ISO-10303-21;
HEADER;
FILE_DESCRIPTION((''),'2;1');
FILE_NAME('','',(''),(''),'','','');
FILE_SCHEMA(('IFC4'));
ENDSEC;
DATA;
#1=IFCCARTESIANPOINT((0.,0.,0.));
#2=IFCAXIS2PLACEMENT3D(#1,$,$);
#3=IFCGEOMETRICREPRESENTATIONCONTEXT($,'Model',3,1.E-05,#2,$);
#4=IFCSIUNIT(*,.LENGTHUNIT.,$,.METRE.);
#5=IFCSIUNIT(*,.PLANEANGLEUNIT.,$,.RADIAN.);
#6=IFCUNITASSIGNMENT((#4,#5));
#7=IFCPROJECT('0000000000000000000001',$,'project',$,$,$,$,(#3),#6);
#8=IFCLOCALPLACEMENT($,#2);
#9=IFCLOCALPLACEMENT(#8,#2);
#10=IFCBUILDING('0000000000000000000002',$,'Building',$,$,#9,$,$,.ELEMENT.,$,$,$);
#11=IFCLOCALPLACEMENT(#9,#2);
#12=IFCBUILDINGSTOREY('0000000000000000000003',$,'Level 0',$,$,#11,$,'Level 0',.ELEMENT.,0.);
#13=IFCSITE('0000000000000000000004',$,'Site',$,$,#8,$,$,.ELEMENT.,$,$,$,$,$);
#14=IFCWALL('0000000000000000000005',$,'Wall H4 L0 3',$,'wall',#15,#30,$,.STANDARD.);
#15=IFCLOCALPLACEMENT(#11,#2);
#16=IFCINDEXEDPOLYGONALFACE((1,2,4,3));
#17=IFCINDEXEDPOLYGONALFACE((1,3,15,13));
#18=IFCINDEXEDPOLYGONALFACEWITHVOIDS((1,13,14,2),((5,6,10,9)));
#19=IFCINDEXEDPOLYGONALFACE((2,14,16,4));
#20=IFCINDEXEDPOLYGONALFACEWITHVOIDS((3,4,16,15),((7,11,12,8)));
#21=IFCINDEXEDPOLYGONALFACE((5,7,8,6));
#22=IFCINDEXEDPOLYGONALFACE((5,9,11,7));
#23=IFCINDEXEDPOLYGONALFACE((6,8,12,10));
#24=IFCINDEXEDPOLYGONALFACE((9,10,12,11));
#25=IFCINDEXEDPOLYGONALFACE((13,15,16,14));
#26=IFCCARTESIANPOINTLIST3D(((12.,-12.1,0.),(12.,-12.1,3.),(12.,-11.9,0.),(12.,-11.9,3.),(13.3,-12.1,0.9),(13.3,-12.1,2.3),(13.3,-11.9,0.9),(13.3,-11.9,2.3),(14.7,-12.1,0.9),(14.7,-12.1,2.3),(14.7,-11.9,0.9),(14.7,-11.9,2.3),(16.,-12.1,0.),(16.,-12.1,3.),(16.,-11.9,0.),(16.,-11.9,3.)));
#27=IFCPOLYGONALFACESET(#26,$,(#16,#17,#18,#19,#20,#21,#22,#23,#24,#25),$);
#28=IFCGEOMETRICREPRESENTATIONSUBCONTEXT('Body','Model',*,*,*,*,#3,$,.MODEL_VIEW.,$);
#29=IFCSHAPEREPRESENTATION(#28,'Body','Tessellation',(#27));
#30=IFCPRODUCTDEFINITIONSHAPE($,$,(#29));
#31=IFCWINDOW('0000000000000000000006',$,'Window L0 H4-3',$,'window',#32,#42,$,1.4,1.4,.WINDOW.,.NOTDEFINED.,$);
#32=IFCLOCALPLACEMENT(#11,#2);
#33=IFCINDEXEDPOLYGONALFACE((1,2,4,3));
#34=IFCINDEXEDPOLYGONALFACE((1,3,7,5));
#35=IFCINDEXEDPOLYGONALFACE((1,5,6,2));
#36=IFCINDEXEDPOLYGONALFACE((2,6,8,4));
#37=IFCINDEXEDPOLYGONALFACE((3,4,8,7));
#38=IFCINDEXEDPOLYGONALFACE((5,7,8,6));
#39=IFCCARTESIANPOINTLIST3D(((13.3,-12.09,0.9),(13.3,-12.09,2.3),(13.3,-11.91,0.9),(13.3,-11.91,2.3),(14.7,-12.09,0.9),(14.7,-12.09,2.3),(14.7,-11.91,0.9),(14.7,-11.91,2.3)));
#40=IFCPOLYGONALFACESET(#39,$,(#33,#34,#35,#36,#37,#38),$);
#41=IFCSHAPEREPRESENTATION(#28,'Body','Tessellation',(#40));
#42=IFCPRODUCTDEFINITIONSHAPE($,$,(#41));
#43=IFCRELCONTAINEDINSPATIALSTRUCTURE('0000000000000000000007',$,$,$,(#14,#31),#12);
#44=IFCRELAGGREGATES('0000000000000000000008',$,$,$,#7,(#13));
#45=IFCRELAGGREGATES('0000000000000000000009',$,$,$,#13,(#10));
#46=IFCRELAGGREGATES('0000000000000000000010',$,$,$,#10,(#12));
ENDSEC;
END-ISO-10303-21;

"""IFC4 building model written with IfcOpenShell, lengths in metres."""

from ifc_helpers import new_model, si_unit, frame, frame_2d, origin, origin_2d, place, context, subcontext, project, spatial, rectangle, extrude, element, fill, save


model = new_model("IFC4")

# Units and contexts
model_context = context("Model", 3, precision=1e-05, world=origin())
body_context = subcontext(model_context, "Body", "Model", "MODEL_VIEW")
ifc_project = project(units=[si_unit("LENGTHUNIT", "METRE"), si_unit("PLANEANGLEUNIT", "RADIAN")], contexts=[model_context])

# Site, building, storey
site_placement = place(None, origin())
site = spatial("IfcSite", under=ifc_project, at=site_placement, Name="Site", CompositionType="ELEMENT")
building_placement = place(site_placement, origin())
building = spatial("IfcBuilding", under=site, at=building_placement, Name="Building", CompositionType="ELEMENT")
storey_placement = place(building_placement, origin())
storey = spatial("IfcBuildingStorey", under=building, at=storey_placement, Name="Level 0", LongName="Level 0", CompositionType="ELEMENT", Elevation=0.0)

# Wall, opening, window
wall_1_placement = place(storey_placement, frame((12.0, -12.0, 0.0), z_axis=(0.0, 0.0, 1.0), x_axis=(1.0, 0.0, 0.0)))
wall_1 = element("IfcWall", 1, at=wall_1_placement, inside=storey, Name="Wall H4 L0 3", ObjectType="wall", PredefinedType="STANDARD", context=body_context, shape_type="SweptSolid", body=[
    extrude(rectangle(XDim=4.0, YDim=0.2, at=frame_2d((2.0, 0.0))), origin(), (0.0, 0.0, 1.0), 3.0),
])
opening_1_placement = place(storey_placement, frame((14.0, -12.0, 0.9), z_axis=(0.0, 0.0, 1.0), x_axis=(1.0, 0.0, 0.0)))
opening_1 = element("IfcOpeningElement", 2, at=opening_1_placement, cuts=wall_1, ObjectType="Opening", PredefinedType="OPENING", context=body_context, shape_type="SweptSolid", body=[
    extrude(rectangle(XDim=1.4, YDim=0.22, at=origin_2d()), origin(), (0.0, 0.0, 1.0), 1.4),
])
window_placement = place(storey_placement, frame((14.0, -12.0, 0.9), z_axis=(0.0, 0.0, 1.0), x_axis=(1.0, 0.0, 0.0)))
window = element("IfcWindow", 3, at=window_placement, inside=storey, Name="Window L0 H4-3", ObjectType="window", OverallHeight=1.4, OverallWidth=1.4, PartitioningType="NOTDEFINED", PredefinedType="WINDOW", context=body_context, shape_type="SweptSolid", body=[
    extrude(rectangle(XDim=1.4, YDim=0.18, at=origin_2d()), origin(), (0.0, 0.0, 1.0), 1.4),
])
fill(opening_1, window)

save(model, "model.ifc")
